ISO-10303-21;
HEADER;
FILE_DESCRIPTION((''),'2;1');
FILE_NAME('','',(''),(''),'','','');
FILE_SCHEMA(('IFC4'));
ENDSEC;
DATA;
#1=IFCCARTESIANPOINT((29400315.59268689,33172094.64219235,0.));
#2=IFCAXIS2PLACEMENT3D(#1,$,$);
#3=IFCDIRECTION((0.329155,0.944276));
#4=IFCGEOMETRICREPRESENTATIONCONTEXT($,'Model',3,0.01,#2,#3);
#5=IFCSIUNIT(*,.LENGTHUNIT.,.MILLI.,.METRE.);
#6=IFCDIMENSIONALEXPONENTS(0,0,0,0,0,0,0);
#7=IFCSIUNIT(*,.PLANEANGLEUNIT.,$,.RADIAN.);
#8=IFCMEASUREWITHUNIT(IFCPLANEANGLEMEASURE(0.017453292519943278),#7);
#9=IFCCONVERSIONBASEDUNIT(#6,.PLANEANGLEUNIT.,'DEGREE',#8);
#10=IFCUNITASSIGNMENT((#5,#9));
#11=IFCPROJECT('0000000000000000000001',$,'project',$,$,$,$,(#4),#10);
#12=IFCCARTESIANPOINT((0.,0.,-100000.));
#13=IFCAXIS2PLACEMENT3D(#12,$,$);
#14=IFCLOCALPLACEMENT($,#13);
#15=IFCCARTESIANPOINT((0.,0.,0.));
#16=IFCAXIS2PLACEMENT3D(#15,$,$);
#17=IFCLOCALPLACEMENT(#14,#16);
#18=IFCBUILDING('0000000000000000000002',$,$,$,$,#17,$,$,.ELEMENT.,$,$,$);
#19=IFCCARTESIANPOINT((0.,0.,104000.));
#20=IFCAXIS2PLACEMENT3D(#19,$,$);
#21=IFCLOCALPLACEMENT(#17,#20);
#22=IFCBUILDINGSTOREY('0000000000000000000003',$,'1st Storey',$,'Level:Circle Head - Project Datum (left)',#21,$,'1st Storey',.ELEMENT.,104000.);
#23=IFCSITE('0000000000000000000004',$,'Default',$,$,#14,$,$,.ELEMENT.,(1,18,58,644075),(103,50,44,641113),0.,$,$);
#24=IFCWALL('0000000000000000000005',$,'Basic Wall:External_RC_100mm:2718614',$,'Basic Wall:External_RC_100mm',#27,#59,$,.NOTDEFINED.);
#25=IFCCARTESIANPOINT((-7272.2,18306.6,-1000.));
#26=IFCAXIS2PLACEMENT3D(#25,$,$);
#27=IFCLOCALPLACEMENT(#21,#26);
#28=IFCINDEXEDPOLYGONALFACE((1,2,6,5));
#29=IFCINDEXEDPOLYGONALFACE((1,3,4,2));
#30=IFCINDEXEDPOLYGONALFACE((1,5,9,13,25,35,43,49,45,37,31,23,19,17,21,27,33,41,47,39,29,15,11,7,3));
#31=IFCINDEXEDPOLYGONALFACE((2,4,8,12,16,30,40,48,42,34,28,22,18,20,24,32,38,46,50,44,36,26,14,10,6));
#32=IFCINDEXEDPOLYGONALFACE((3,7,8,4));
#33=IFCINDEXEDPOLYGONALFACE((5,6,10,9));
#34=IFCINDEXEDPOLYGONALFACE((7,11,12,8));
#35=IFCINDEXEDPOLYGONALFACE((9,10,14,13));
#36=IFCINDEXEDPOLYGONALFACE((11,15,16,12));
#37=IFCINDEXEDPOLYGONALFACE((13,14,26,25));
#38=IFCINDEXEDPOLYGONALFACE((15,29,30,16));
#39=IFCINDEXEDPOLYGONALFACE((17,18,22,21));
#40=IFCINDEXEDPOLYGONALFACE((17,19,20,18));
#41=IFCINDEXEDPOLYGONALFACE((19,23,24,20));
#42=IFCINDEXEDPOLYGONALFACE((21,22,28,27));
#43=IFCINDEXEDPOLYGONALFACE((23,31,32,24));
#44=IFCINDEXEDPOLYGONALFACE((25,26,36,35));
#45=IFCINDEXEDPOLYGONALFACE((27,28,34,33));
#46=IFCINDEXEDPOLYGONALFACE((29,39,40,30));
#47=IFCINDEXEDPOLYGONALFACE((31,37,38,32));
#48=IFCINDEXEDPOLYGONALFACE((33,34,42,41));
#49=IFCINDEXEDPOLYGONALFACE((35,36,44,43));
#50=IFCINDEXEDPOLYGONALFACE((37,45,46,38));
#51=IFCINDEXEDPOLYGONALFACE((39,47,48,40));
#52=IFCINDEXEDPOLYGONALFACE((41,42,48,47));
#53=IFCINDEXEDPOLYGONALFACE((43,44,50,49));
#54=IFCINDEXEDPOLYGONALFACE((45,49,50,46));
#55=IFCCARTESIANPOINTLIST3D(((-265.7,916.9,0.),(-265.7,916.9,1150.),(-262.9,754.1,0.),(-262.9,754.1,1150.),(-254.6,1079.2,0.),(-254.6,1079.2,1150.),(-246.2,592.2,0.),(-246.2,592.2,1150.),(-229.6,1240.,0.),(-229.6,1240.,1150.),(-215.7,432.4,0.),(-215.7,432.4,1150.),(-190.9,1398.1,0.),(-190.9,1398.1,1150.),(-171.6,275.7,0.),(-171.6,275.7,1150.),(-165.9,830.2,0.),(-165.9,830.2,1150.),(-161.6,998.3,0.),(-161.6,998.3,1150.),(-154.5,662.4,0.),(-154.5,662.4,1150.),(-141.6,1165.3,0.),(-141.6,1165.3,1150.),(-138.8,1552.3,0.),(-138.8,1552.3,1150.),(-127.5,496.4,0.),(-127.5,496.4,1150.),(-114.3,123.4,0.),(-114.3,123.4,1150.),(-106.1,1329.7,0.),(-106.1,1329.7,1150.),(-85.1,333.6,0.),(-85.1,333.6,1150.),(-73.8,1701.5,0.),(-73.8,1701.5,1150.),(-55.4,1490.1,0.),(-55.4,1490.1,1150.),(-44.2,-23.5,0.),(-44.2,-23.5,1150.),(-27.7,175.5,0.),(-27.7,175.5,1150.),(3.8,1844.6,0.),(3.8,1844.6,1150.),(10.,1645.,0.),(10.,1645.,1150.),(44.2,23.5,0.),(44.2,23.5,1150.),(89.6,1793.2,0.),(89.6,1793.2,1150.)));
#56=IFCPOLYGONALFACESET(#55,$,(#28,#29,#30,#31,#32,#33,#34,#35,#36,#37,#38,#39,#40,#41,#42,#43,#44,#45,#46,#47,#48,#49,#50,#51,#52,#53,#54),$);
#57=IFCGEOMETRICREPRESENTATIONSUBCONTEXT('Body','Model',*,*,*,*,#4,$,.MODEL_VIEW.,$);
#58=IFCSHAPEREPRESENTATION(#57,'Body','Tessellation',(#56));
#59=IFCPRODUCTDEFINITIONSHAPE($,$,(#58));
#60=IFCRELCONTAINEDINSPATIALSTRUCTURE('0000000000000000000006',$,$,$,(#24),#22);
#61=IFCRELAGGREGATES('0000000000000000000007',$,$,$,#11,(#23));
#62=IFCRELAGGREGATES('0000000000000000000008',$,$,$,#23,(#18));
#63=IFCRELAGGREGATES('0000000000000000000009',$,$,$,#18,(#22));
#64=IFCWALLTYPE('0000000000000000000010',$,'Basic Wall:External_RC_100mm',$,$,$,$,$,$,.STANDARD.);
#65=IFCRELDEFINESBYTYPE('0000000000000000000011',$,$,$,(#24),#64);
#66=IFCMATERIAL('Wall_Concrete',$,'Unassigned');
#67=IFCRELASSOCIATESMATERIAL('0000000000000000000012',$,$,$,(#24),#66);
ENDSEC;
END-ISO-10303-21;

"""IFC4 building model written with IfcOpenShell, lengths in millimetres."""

from ifc_helpers import new_model, entity, si_unit, converted_unit, direction, frame, origin, place, context, subcontext, project, spatial, line, arc, indexed_curve, outline, extrude, material, type_object, element, save


model = new_model("IFC4")

# Units and contexts
model_context = context("Model", 3, precision=0.01, world=frame((29400315.59268689, 33172094.64219235, 0.0)), true_north=direction((0.329155, 0.944276)))
body_context = subcontext(model_context, "Body", "Model", "MODEL_VIEW")
ifc_project = project(units=[si_unit("LENGTHUNIT", "METRE", prefix="MILLI"), converted_unit("PLANEANGLEUNIT", "DEGREE", entity("IfcPlaneAngleMeasure", 0.017453292519943278), si_unit("PLANEANGLEUNIT", "RADIAN"), dimensions=[0, 0, 0, 0, 0, 0, 0])], contexts=[model_context])

# Site, building, storey
site_placement = place(None, frame((0.0, 0.0, -100000.0)))
site = spatial("IfcSite", under=ifc_project, at=site_placement, Name="Default", CompositionType="ELEMENT", RefLatitude=(1, 18, 58, 644075), RefLongitude=(103, 50, 44, 641113), RefElevation=0.0)
building_placement = place(site_placement, origin())
building = spatial("IfcBuilding", under=site, at=building_placement, CompositionType="ELEMENT")
storey_placement = place(building_placement, frame((0.0, 0.0, 104000.0)))
storey = spatial("IfcBuildingStorey", under=building, at=storey_placement, Name="1st Storey", ObjectType="Level:Circle Head - Project Datum (left)", LongName="1st Storey", CompositionType="ELEMENT", Elevation=104000.0)

# Wall
ifc_material_1 = material(Name="Wall_Concrete", Category="Unassigned")
wall_type_1 = type_object("IfcWallType", Name="Basic Wall:External_RC_100mm", PredefinedType="STANDARD")
wall_1_placement = place(storey_placement, frame((-7272.2, 18306.6, -1000.0)))
element("IfcWall", 1, at=wall_1_placement, inside=storey, type_object=wall_type_1, material=ifc_material_1, Name="Basic Wall:External_RC_100mm:2718614", ObjectType="Basic Wall:External_RC_100mm", PredefinedType="NOTDEFINED", context=body_context, shape_type="SweptSolid", body=[
    extrude(outline(indexed_curve([(3.8, 1844.6), (-265.7, 916.9), (-44.2, -23.5), (44.2, 23.5), (-165.7, 914.3), (89.6, 1793.2)], segments=[arc(1, 2, 3), line(3, 4), arc(4, 5, 6), line(6, 1)], self_intersect=False)), origin(), (0.0, 0.0, 1.0), 1150.0),
])

save(model, "model.ifc")
